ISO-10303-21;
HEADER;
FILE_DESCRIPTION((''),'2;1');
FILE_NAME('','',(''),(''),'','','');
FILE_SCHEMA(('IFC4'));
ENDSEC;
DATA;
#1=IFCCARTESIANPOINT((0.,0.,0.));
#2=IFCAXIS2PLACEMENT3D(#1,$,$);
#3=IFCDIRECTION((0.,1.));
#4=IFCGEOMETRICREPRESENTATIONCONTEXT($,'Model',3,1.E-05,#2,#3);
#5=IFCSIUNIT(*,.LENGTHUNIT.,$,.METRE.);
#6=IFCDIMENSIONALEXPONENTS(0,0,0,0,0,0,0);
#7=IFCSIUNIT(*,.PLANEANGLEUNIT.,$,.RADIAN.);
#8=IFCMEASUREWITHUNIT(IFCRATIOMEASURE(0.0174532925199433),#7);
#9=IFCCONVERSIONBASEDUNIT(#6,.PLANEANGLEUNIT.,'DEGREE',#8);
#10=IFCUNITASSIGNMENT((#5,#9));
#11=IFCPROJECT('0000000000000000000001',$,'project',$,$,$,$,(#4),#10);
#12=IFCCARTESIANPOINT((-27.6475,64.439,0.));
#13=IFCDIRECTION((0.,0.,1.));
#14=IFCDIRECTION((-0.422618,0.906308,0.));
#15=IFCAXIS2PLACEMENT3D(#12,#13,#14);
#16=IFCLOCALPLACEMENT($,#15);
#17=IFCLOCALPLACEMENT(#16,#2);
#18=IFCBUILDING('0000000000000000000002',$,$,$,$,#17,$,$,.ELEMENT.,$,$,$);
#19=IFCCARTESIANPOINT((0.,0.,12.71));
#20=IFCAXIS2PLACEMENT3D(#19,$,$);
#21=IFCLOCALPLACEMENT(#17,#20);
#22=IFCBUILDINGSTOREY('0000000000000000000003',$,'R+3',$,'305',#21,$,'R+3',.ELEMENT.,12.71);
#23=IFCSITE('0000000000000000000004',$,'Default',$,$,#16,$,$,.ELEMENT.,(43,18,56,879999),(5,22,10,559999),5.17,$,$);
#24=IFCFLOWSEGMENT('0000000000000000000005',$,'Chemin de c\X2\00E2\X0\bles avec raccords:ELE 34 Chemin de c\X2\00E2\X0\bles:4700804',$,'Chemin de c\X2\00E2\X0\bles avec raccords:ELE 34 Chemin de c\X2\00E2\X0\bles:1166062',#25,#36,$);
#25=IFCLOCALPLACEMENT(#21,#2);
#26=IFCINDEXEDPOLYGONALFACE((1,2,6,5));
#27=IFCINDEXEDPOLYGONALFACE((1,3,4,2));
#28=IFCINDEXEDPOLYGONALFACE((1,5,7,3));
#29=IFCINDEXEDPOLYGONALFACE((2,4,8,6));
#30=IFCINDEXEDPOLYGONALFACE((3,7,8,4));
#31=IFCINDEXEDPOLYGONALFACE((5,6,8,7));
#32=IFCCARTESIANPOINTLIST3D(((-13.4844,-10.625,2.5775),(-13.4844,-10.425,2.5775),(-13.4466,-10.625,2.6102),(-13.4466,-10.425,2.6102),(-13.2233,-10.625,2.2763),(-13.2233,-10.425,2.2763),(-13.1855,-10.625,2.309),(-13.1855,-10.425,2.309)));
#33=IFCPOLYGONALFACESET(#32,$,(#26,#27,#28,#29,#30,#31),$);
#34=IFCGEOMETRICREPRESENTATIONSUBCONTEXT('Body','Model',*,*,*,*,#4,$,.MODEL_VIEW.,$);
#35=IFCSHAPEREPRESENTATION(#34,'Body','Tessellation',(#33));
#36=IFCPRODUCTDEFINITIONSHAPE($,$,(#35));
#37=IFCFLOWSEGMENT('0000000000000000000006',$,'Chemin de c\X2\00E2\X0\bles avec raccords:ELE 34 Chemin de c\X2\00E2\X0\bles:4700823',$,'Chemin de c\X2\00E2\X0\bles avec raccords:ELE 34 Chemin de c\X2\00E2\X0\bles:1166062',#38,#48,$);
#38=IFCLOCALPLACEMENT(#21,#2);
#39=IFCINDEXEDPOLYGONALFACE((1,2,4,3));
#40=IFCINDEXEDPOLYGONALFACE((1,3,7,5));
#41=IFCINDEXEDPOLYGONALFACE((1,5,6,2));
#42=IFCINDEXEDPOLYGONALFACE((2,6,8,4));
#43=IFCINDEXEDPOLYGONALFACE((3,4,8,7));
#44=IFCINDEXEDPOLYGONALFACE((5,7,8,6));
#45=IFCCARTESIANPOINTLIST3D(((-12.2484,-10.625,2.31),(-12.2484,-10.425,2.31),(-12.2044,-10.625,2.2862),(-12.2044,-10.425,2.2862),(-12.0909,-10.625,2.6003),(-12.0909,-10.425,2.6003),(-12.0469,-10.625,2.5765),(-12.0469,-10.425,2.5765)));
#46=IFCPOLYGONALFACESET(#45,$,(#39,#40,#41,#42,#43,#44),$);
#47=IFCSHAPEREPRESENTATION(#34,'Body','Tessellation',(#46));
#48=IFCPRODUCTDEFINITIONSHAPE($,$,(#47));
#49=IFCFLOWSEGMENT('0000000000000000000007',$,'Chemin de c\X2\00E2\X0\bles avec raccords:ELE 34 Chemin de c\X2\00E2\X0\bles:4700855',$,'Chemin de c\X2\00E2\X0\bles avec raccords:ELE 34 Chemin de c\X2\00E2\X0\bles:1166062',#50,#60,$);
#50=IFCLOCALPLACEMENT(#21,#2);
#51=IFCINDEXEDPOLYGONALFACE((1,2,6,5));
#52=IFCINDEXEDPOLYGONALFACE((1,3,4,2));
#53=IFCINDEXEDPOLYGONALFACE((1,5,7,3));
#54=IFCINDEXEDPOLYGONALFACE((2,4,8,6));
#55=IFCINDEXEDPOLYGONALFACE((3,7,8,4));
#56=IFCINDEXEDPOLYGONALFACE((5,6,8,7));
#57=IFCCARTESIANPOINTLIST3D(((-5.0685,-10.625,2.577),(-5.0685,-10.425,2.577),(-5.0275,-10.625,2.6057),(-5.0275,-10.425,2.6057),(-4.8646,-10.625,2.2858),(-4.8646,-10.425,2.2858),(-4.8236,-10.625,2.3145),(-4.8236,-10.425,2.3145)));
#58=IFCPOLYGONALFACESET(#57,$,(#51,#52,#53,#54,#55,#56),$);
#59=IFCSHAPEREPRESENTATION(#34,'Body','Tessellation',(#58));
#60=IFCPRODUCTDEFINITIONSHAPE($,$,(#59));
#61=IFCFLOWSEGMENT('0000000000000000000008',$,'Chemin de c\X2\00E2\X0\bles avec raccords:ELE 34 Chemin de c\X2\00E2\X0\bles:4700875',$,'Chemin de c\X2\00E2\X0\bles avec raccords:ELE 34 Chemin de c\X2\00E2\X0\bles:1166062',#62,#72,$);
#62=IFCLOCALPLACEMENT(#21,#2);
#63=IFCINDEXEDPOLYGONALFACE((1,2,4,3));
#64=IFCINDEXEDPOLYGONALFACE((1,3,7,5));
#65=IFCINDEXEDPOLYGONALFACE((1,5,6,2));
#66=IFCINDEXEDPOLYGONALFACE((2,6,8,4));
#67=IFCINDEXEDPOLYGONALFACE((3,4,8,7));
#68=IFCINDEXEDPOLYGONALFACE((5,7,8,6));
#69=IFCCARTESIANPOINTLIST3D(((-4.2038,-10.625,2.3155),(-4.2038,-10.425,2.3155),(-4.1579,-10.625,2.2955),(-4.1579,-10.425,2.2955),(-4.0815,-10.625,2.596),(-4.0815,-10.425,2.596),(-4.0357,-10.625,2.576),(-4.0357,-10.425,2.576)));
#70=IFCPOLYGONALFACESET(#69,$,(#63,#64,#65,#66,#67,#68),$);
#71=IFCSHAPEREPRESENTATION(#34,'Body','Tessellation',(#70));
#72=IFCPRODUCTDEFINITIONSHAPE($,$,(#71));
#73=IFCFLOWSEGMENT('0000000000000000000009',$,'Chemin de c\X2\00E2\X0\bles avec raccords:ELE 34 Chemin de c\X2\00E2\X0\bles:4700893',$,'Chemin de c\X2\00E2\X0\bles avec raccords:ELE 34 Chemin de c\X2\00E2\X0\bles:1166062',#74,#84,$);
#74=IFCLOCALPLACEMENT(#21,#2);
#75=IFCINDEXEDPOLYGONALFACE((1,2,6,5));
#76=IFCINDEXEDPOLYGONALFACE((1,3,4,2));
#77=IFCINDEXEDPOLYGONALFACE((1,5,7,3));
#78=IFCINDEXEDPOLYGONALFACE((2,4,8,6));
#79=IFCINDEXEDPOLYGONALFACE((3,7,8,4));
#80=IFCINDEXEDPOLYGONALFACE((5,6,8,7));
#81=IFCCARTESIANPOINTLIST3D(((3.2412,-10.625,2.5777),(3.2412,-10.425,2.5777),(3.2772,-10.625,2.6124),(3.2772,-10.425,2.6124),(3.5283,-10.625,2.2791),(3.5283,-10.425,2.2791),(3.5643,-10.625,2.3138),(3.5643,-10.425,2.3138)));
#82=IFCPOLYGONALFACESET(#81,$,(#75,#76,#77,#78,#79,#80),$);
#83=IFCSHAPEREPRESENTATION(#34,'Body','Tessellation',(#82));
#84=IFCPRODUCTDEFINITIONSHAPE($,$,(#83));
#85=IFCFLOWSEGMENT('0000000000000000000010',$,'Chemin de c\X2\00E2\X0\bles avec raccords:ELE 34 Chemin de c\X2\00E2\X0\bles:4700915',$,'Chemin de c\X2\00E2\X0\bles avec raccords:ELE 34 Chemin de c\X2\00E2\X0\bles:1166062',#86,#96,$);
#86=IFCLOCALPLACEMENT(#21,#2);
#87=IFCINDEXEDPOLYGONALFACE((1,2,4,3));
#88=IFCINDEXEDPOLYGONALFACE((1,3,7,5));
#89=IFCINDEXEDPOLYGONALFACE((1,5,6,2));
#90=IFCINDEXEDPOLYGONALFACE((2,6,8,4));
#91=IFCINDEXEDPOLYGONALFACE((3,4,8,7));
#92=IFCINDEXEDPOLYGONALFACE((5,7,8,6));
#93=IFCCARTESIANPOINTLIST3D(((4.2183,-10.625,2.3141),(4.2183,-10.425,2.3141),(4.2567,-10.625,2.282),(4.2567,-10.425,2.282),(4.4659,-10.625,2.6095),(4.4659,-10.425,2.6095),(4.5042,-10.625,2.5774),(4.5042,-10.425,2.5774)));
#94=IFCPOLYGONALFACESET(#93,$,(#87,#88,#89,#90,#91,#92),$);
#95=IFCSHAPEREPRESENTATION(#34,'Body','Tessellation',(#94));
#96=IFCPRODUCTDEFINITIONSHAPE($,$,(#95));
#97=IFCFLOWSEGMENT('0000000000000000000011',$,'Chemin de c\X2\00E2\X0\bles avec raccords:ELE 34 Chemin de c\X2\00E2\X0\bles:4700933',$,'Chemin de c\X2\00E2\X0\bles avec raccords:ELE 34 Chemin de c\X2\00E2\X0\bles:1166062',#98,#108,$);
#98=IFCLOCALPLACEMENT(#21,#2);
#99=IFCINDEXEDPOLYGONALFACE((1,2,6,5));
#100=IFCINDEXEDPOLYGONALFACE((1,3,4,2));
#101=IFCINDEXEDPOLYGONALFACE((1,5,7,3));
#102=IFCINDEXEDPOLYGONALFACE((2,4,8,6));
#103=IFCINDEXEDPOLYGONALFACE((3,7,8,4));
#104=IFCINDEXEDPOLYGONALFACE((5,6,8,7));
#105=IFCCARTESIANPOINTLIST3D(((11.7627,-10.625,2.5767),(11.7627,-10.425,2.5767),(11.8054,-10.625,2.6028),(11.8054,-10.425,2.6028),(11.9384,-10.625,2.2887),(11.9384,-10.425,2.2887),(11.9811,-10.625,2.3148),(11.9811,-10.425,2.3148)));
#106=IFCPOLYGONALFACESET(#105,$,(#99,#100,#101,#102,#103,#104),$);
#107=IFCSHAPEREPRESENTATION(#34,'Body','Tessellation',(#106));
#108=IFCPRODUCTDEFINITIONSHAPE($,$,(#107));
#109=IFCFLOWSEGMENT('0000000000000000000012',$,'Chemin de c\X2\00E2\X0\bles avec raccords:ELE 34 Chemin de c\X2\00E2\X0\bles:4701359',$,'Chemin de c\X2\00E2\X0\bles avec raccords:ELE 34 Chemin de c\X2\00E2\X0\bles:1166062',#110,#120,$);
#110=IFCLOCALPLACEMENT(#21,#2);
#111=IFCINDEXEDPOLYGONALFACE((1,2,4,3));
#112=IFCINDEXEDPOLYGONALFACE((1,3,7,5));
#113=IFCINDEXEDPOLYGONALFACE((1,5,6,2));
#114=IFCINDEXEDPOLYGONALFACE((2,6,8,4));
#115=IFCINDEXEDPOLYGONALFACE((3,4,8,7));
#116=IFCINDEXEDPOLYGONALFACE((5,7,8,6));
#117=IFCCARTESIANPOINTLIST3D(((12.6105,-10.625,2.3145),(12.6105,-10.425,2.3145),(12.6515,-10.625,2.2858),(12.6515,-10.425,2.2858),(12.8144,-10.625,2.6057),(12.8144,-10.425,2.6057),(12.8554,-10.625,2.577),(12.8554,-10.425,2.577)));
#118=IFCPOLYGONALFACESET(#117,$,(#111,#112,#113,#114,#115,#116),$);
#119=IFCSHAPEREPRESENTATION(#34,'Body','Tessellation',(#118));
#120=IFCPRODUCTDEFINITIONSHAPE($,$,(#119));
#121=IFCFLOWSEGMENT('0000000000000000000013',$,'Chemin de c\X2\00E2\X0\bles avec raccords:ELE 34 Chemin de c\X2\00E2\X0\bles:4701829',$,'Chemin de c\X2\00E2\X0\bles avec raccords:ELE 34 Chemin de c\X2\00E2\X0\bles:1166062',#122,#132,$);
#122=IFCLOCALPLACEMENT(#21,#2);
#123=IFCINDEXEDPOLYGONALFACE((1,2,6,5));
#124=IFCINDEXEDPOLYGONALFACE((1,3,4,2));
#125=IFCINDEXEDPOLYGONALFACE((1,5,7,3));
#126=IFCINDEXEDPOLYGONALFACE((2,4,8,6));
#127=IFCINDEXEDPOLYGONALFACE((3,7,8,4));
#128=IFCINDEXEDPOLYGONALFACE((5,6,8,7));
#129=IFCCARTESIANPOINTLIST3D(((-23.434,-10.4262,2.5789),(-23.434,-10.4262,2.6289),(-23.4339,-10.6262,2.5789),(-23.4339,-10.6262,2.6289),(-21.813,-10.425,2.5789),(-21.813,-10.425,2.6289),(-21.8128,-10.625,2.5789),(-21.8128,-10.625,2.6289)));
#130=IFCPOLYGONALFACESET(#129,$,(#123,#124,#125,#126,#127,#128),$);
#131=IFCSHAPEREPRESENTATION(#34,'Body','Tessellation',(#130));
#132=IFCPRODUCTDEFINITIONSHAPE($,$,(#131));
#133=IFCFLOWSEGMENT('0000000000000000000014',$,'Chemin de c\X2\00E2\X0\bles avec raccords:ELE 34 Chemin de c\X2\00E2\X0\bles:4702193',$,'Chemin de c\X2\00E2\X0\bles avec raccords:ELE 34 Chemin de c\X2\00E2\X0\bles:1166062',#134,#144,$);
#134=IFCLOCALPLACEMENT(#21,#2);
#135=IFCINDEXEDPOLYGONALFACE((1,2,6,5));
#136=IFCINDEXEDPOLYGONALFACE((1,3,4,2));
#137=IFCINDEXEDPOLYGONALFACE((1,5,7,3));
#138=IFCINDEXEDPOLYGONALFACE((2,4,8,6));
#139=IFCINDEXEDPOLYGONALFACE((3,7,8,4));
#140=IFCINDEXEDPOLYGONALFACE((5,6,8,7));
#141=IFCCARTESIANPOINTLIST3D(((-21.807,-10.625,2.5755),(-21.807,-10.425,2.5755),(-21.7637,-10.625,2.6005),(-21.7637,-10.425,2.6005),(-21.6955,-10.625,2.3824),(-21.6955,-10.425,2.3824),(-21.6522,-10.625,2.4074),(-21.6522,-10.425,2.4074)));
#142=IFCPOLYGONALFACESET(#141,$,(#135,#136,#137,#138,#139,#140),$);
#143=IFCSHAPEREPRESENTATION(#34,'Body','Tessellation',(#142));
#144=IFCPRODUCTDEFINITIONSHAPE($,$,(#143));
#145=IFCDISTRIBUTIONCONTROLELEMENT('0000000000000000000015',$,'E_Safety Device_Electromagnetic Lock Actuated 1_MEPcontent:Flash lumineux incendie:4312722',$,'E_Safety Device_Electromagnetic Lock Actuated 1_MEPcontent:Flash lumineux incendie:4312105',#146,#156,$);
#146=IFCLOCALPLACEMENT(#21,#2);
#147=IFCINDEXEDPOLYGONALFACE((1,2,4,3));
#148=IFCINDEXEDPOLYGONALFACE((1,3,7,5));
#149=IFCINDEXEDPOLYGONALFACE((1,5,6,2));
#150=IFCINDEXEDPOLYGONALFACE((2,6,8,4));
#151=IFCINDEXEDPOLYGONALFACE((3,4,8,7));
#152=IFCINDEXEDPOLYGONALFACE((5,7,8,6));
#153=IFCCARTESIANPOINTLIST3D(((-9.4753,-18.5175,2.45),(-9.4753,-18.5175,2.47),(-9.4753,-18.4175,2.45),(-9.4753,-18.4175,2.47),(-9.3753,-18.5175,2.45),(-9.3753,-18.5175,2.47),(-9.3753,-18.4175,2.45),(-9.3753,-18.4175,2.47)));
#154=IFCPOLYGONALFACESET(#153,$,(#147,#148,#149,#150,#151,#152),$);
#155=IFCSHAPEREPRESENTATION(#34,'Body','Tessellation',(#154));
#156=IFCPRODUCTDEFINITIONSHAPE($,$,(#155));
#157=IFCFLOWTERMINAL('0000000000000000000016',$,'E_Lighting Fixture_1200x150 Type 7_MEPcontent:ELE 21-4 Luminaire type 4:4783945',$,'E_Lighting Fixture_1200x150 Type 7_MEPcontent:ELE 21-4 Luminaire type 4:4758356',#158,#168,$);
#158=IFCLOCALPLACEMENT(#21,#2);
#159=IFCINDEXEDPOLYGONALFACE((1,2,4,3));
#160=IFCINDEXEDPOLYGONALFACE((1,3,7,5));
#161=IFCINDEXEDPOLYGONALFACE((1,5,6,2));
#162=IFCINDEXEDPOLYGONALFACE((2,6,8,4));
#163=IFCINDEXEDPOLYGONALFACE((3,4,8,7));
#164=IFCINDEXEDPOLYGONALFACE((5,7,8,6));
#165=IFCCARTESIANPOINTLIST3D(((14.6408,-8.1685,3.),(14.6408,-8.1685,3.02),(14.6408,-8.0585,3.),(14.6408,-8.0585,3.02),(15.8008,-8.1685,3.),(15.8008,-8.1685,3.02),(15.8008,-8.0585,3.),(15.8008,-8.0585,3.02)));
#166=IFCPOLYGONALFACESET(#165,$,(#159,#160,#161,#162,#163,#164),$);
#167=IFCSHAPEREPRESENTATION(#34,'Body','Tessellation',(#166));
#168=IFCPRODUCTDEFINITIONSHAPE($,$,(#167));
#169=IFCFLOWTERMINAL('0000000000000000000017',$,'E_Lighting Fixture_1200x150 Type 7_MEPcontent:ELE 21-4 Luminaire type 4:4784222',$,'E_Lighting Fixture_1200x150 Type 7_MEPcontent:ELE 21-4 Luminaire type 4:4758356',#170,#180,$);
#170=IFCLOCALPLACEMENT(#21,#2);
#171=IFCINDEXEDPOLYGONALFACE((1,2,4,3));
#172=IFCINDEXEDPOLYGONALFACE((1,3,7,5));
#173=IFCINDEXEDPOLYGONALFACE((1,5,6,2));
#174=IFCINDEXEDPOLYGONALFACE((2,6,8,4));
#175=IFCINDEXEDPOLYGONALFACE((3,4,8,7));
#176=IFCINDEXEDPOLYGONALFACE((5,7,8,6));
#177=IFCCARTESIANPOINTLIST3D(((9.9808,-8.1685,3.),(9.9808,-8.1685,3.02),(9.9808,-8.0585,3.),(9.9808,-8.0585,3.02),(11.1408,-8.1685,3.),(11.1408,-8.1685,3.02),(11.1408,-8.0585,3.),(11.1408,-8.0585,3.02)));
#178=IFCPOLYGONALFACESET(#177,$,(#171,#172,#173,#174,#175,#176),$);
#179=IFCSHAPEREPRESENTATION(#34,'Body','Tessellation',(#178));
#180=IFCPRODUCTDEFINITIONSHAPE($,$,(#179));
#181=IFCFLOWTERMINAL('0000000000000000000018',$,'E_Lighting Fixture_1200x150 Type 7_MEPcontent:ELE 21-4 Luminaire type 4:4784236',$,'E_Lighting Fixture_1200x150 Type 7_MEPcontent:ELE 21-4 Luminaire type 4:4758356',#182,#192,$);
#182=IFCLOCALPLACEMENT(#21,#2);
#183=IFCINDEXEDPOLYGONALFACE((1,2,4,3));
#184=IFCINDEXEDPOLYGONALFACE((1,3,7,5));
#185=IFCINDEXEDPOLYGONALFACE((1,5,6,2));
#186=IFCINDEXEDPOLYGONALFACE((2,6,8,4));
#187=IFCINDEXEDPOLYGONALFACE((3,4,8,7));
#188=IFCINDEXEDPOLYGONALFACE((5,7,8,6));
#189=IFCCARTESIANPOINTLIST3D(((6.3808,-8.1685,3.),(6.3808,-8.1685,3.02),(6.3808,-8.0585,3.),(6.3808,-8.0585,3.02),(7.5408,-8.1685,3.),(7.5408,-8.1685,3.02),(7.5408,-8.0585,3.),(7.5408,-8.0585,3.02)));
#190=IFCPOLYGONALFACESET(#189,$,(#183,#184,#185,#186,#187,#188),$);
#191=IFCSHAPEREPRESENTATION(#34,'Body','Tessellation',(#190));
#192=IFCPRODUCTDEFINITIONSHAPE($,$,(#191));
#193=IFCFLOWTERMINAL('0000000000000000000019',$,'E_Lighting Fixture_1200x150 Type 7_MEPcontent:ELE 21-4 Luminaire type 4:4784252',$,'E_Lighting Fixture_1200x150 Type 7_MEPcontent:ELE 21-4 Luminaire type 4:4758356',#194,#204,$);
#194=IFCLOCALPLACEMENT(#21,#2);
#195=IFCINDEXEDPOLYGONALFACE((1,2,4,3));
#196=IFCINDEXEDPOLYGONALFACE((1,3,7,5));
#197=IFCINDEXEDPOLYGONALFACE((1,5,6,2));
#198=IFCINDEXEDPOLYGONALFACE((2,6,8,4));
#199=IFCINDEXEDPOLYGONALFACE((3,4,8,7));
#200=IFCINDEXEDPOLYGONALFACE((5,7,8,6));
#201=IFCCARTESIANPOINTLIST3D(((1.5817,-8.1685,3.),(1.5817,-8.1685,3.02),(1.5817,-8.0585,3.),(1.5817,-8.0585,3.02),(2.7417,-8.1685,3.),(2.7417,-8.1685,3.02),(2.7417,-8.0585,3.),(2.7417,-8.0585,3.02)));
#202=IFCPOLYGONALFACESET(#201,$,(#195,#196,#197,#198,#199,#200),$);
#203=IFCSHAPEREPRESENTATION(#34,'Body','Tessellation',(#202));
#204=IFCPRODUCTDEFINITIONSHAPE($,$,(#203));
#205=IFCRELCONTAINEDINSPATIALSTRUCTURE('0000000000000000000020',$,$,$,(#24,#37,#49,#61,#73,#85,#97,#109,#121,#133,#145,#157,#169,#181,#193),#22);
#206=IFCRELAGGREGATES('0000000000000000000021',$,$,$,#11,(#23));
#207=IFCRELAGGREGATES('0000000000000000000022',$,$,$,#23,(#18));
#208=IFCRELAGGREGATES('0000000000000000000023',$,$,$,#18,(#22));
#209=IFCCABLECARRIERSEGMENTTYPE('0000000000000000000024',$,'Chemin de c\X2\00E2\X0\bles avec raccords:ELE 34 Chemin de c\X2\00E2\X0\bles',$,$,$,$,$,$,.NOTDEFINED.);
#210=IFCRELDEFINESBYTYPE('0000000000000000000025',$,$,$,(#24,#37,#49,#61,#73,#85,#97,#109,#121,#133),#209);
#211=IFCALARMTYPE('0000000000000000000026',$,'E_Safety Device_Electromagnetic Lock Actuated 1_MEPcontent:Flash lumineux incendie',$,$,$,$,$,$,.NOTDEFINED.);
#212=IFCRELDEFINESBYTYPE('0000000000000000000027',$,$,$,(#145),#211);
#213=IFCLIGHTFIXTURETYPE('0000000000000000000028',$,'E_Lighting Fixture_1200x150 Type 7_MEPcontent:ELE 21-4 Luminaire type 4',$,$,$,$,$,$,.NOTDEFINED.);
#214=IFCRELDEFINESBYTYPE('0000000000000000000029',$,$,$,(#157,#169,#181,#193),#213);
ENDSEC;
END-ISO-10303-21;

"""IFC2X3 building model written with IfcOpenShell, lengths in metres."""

from ifc_helpers import new_model, entity, si_unit, converted_unit, direction, frame, frame_2d, origin, origin_2d_with_axis, place, context, subcontext, project, spatial, rectangle, extrude, source, transform, mapped, type_object, type_shapes, element, save


model = new_model("IFC2X3")

# Units and contexts
model_context = context("Model", 3, precision=1e-05, world=origin(), true_north=direction((0.0, 1.0)))
body_context = subcontext(model_context, "Body", "Model", "MODEL_VIEW")
ifc_project = project(units=[si_unit("LENGTHUNIT", "METRE"), converted_unit("PLANEANGLEUNIT", "DEGREE", entity("IfcRatioMeasure", 0.0174532925199433), si_unit("PLANEANGLEUNIT", "RADIAN"), dimensions=[0, 0, 0, 0, 0, 0, 0])], contexts=[model_context])

# Site, building, storey
site_placement = place(None, frame((-27.6475, 64.439, 0.0), z_axis=(0.0, 0.0, 1.0), x_axis=(-0.422618, 0.906308, 0.0)))
site = spatial("IfcSite", under=ifc_project, at=site_placement, Name="Default", CompositionType="ELEMENT", RefLatitude=(43, 18, 56, 879999), RefLongitude=(5, 22, 10, 559999), RefElevation=5.17)
building_placement = place(site_placement, origin())
building = spatial("IfcBuilding", under=site, at=building_placement, CompositionType="ELEMENT")
storey_placement = place(building_placement, frame((0.0, 0.0, 12.71)))
storey = spatial("IfcBuildingStorey", under=building, at=storey_placement, Name="R+3", ObjectType="305", LongName="R+3", CompositionType="ELEMENT", Elevation=12.71)

# Flow segments
cable_carrier_segment_type = type_object("IfcCableCarrierSegmentType", Name="Chemin de câbles avec raccords:ELE 34 Chemin de câbles", PredefinedType="NOTDEFINED")
flow_segment_1_placement = place(storey_placement, origin())
element("IfcFlowSegment", 1, at=flow_segment_1_placement, inside=storey, type_object=cable_carrier_segment_type, Name="Chemin de câbles avec raccords:ELE 34 Chemin de câbles:4700804", ObjectType="Chemin de câbles avec raccords:ELE 34 Chemin de câbles:1166062", context=body_context, shape_type="SweptSolid", body=[
    extrude(rectangle(XDim=0.05, YDim=0.2, at=frame_2d((0.0, 0.0), x_axis=(0.0, 1.0))), frame((-13.2044, -10.525, 2.2926), z_axis=(-0.655002, 0.0, 0.755627), x_axis=(0.0, -1.0, 0.0)), (0.0, 0.0, 1.0), 0.3987),
])
flow_segment_2_placement = place(storey_placement, origin())
element("IfcFlowSegment", 2, at=flow_segment_2_placement, inside=storey, type_object=cable_carrier_segment_type, Name="Chemin de câbles avec raccords:ELE 34 Chemin de câbles:4700823", ObjectType="Chemin de câbles avec raccords:ELE 34 Chemin de câbles:1166062", context=body_context, shape_type="SweptSolid", body=[
    extrude(rectangle(XDim=0.05, YDim=0.2, at=frame_2d((0.0, 0.0), x_axis=(0.0, 1.0))), frame((-12.2264, -10.525, 2.2981), z_axis=(0.476893, 0.0, 0.878961), x_axis=(0.0, 1.0, 0.0)), (0.0, 0.0, 1.0), 0.3303),
])
flow_segment_3_placement = place(storey_placement, origin())
element("IfcFlowSegment", 3, at=flow_segment_3_placement, inside=storey, type_object=cable_carrier_segment_type, Name="Chemin de câbles avec raccords:ELE 34 Chemin de câbles:4700855", ObjectType="Chemin de câbles avec raccords:ELE 34 Chemin de câbles:1166062", context=body_context, shape_type="SweptSolid", body=[
    extrude(rectangle(XDim=0.05, YDim=0.2, at=frame_2d((0.0, 0.0), x_axis=(0.0, 1.0))), frame((-4.8441, -10.525, 2.3001), z_axis=(-0.573513, 0.0, 0.819197), x_axis=(0.0, -1.0, 0.0)), (0.0, 0.0, 1.0), 0.3555),
])
flow_segment_4_placement = place(storey_placement, origin())
element("IfcFlowSegment", 4, at=flow_segment_4_placement, inside=storey, type_object=cable_carrier_segment_type, Name="Chemin de câbles avec raccords:ELE 34 Chemin de câbles:4700875", ObjectType="Chemin de câbles avec raccords:ELE 34 Chemin de câbles:1166062", context=body_context, shape_type="SweptSolid", body=[
    extrude(rectangle(XDim=0.05, YDim=0.2, at=frame_2d((0.0, 0.0), x_axis=(1.0, 0.0))), frame((-4.1809, -10.525, 2.3055), z_axis=(0.399456, 0.0, 0.916752), x_axis=(-0.916752, 0.0, 0.399456)), (0.0, 0.0, 1.0), 0.306),
])
flow_segment_5_placement = place(storey_placement, origin())
element("IfcFlowSegment", 5, at=flow_segment_5_placement, inside=storey, type_object=cable_carrier_segment_type, Name="Chemin de câbles avec raccords:ELE 34 Chemin de câbles:4700893", ObjectType="Chemin de câbles avec raccords:ELE 34 Chemin de câbles:1166062", context=body_context, shape_type="SweptSolid", body=[
    extrude(rectangle(XDim=0.05, YDim=0.2, at=frame_2d((0.0, 0.0), x_axis=(0.0, 1.0))), frame((3.5463, -10.525, 2.2964), z_axis=(-0.693059, 0.0, 0.720881), x_axis=(0.0, -1.0, 0.0)), (0.0, 0.0, 1.0), 0.4142),
])
flow_segment_6_placement = place(storey_placement, origin())
element("IfcFlowSegment", 6, at=flow_segment_6_placement, inside=storey, type_object=cable_carrier_segment_type, Name="Chemin de câbles avec raccords:ELE 34 Chemin de câbles:4700915", ObjectType="Chemin de câbles avec raccords:ELE 34 Chemin de câbles:1166062", context=body_context, shape_type="SweptSolid", body=[
    extrude(rectangle(XDim=0.05, YDim=0.2, at=frame_2d((0.0, 0.0), x_axis=(1.0, 0.0))), frame((4.2375, -10.525, 2.298), z_axis=(0.642257, 0.0, 0.76649), x_axis=(-0.76649, 0.0, 0.642257)), (0.0, 0.0, 1.0), 0.3855),
])
flow_segment_7_placement = place(storey_placement, origin())
element("IfcFlowSegment", 7, at=flow_segment_7_placement, inside=storey, type_object=cable_carrier_segment_type, Name="Chemin de câbles avec raccords:ELE 34 Chemin de câbles:4700933", ObjectType="Chemin de câbles avec raccords:ELE 34 Chemin de câbles:1166062", context=body_context, shape_type="SweptSolid", body=[
    extrude(rectangle(XDim=0.05, YDim=0.2, at=frame_2d((0.0, 0.0), x_axis=(0.0, 1.0))), frame((11.9597, -10.525, 2.3018), z_axis=(-0.520788, 0.0, 0.853686), x_axis=(0.0, -1.0, 0.0)), (0.0, 0.0, 1.0), 0.3373),
])
flow_segment_8_placement = place(storey_placement, origin())
element("IfcFlowSegment", 8, at=flow_segment_8_placement, inside=storey, type_object=cable_carrier_segment_type, Name="Chemin de câbles avec raccords:ELE 34 Chemin de câbles:4701359", ObjectType="Chemin de câbles avec raccords:ELE 34 Chemin de câbles:1166062", context=body_context, shape_type="SweptSolid", body=[
    extrude(rectangle(XDim=0.05, YDim=0.2, at=frame_2d((0.0, 0.0), x_axis=(0.0, 1.0))), frame((12.631, -10.525, 2.3001), z_axis=(0.573576, 0.0, 0.819152), x_axis=(0.0, 1.0, 0.0)), (0.0, 0.0, 1.0), 0.3555),
])
flow_segment_9_placement = place(storey_placement, origin())
element("IfcFlowSegment", 9, at=flow_segment_9_placement, inside=storey, type_object=cable_carrier_segment_type, Name="Chemin de câbles avec raccords:ELE 34 Chemin de câbles:4701829", ObjectType="Chemin de câbles avec raccords:ELE 34 Chemin de câbles:1166062", context=body_context, shape_type="SweptSolid", body=[
    extrude(rectangle(XDim=1.6211, YDim=0.2, at=frame_2d((0.0, 0.0), x_axis=(1.0, 0.0))), frame((-22.6234, -10.5256, 2.5789), z_axis=(0.0, 0.0, 1.0), x_axis=(1.0, 0.000726, 0.0)), (0.0, 0.0, 1.0), 0.05),
])
flow_segment_10_placement = place(storey_placement, origin())
element("IfcFlowSegment", 10, at=flow_segment_10_placement, inside=storey, type_object=cable_carrier_segment_type, Name="Chemin de câbles avec raccords:ELE 34 Chemin de câbles:4702193", ObjectType="Chemin de câbles avec raccords:ELE 34 Chemin de câbles:1166062", context=body_context, shape_type="SweptSolid", body=[
    extrude(rectangle(XDim=0.05, YDim=0.2, at=frame_2d((0.0, 0.0), x_axis=(0.0, 1.0))), frame((-21.6739, -10.525, 2.3949), z_axis=(-0.5, 0.0, 0.866025), x_axis=(0.0, -1.0, 0.0)), (0.0, 0.0, 1.0), 0.223),
])

# Distribution control element
alarm_type = type_object("IfcAlarmType", Name="E_Safety Device_Electromagnetic Lock Actuated 1_MEPcontent:Flash lumineux incendie", PredefinedType="NOTDEFINED")
shared_shape_1 = source(origin(), body_context, "Body", "SweptSolid", [
    extrude(rectangle(XDim=0.1, YDim=0.1, at=origin_2d_with_axis()), frame((0.0, 0.0, 0.0), z_axis=(0.0, 0.0, 1.0), x_axis=(0.0, -1.0, 0.0)), (0.0, 0.0, 1.0), 0.02),
])
type_shapes(alarm_type, [shared_shape_1])
distribution_control_element_placement = place(storey_placement, frame((-9.4253, -18.4675, 2.45), z_axis=(0.0, 0.0, 1.0), x_axis=(0.0, -1.0, 0.0)))
element("IfcDistributionControlElement", 11, at=distribution_control_element_placement, inside=storey, type_object=alarm_type, Name="E_Safety Device_Electromagnetic Lock Actuated 1_MEPcontent:Flash lumineux incendie:4312722", ObjectType="E_Safety Device_Electromagnetic Lock Actuated 1_MEPcontent:Flash lumineux incendie:4312105", context=body_context, shape_type="MappedRepresentation", body=[
    mapped(shared_shape_1, transform((0.0, 0.0, 0.0), scale=1.0)),
])

# Flow terminals
light_fixture_type = type_object("IfcLightFixtureType", Name="E_Lighting Fixture_1200x150 Type 7_MEPcontent:ELE 21-4 Luminaire type 4", PredefinedType="NOTDEFINED")
shared_shape_2 = source(origin(), body_context, "Body", "SweptSolid", [
    extrude(rectangle(XDim=0.11, YDim=1.16, at=origin_2d_with_axis()), frame((0.0, 0.0, 0.0), z_axis=(0.0, 0.0, 1.0), x_axis=(0.0, -1.0, 0.0)), (0.0, 0.0, 1.0), 0.02),
])
type_shapes(light_fixture_type, [shared_shape_2])
for number, where, name in (
    (12, (15.2208, -8.1135, 3.0), "E_Lighting Fixture_1200x150 Type 7_MEPcontent:ELE 21-4 Luminaire type 4:4783945"),
    (13, (10.5608, -8.1135, 3.0), "E_Lighting Fixture_1200x150 Type 7_MEPcontent:ELE 21-4 Luminaire type 4:4784222"),
    (14, (6.9608, -8.1135, 3.0), "E_Lighting Fixture_1200x150 Type 7_MEPcontent:ELE 21-4 Luminaire type 4:4784236"),
    (15, (2.1617, -8.1135, 3.0), "E_Lighting Fixture_1200x150 Type 7_MEPcontent:ELE 21-4 Luminaire type 4:4784252"),
):
    element("IfcFlowTerminal", number, at=place(storey_placement, frame(where)), inside=storey, type_object=light_fixture_type, Name=name, ObjectType="E_Lighting Fixture_1200x150 Type 7_MEPcontent:ELE 21-4 Luminaire type 4:4758356", context=body_context, shape_type="MappedRepresentation", body=[
        mapped(shared_shape_2, transform((0.0, 0.0, 0.0), scale=1.0)),
    ])

save(model, "model.ifc")
